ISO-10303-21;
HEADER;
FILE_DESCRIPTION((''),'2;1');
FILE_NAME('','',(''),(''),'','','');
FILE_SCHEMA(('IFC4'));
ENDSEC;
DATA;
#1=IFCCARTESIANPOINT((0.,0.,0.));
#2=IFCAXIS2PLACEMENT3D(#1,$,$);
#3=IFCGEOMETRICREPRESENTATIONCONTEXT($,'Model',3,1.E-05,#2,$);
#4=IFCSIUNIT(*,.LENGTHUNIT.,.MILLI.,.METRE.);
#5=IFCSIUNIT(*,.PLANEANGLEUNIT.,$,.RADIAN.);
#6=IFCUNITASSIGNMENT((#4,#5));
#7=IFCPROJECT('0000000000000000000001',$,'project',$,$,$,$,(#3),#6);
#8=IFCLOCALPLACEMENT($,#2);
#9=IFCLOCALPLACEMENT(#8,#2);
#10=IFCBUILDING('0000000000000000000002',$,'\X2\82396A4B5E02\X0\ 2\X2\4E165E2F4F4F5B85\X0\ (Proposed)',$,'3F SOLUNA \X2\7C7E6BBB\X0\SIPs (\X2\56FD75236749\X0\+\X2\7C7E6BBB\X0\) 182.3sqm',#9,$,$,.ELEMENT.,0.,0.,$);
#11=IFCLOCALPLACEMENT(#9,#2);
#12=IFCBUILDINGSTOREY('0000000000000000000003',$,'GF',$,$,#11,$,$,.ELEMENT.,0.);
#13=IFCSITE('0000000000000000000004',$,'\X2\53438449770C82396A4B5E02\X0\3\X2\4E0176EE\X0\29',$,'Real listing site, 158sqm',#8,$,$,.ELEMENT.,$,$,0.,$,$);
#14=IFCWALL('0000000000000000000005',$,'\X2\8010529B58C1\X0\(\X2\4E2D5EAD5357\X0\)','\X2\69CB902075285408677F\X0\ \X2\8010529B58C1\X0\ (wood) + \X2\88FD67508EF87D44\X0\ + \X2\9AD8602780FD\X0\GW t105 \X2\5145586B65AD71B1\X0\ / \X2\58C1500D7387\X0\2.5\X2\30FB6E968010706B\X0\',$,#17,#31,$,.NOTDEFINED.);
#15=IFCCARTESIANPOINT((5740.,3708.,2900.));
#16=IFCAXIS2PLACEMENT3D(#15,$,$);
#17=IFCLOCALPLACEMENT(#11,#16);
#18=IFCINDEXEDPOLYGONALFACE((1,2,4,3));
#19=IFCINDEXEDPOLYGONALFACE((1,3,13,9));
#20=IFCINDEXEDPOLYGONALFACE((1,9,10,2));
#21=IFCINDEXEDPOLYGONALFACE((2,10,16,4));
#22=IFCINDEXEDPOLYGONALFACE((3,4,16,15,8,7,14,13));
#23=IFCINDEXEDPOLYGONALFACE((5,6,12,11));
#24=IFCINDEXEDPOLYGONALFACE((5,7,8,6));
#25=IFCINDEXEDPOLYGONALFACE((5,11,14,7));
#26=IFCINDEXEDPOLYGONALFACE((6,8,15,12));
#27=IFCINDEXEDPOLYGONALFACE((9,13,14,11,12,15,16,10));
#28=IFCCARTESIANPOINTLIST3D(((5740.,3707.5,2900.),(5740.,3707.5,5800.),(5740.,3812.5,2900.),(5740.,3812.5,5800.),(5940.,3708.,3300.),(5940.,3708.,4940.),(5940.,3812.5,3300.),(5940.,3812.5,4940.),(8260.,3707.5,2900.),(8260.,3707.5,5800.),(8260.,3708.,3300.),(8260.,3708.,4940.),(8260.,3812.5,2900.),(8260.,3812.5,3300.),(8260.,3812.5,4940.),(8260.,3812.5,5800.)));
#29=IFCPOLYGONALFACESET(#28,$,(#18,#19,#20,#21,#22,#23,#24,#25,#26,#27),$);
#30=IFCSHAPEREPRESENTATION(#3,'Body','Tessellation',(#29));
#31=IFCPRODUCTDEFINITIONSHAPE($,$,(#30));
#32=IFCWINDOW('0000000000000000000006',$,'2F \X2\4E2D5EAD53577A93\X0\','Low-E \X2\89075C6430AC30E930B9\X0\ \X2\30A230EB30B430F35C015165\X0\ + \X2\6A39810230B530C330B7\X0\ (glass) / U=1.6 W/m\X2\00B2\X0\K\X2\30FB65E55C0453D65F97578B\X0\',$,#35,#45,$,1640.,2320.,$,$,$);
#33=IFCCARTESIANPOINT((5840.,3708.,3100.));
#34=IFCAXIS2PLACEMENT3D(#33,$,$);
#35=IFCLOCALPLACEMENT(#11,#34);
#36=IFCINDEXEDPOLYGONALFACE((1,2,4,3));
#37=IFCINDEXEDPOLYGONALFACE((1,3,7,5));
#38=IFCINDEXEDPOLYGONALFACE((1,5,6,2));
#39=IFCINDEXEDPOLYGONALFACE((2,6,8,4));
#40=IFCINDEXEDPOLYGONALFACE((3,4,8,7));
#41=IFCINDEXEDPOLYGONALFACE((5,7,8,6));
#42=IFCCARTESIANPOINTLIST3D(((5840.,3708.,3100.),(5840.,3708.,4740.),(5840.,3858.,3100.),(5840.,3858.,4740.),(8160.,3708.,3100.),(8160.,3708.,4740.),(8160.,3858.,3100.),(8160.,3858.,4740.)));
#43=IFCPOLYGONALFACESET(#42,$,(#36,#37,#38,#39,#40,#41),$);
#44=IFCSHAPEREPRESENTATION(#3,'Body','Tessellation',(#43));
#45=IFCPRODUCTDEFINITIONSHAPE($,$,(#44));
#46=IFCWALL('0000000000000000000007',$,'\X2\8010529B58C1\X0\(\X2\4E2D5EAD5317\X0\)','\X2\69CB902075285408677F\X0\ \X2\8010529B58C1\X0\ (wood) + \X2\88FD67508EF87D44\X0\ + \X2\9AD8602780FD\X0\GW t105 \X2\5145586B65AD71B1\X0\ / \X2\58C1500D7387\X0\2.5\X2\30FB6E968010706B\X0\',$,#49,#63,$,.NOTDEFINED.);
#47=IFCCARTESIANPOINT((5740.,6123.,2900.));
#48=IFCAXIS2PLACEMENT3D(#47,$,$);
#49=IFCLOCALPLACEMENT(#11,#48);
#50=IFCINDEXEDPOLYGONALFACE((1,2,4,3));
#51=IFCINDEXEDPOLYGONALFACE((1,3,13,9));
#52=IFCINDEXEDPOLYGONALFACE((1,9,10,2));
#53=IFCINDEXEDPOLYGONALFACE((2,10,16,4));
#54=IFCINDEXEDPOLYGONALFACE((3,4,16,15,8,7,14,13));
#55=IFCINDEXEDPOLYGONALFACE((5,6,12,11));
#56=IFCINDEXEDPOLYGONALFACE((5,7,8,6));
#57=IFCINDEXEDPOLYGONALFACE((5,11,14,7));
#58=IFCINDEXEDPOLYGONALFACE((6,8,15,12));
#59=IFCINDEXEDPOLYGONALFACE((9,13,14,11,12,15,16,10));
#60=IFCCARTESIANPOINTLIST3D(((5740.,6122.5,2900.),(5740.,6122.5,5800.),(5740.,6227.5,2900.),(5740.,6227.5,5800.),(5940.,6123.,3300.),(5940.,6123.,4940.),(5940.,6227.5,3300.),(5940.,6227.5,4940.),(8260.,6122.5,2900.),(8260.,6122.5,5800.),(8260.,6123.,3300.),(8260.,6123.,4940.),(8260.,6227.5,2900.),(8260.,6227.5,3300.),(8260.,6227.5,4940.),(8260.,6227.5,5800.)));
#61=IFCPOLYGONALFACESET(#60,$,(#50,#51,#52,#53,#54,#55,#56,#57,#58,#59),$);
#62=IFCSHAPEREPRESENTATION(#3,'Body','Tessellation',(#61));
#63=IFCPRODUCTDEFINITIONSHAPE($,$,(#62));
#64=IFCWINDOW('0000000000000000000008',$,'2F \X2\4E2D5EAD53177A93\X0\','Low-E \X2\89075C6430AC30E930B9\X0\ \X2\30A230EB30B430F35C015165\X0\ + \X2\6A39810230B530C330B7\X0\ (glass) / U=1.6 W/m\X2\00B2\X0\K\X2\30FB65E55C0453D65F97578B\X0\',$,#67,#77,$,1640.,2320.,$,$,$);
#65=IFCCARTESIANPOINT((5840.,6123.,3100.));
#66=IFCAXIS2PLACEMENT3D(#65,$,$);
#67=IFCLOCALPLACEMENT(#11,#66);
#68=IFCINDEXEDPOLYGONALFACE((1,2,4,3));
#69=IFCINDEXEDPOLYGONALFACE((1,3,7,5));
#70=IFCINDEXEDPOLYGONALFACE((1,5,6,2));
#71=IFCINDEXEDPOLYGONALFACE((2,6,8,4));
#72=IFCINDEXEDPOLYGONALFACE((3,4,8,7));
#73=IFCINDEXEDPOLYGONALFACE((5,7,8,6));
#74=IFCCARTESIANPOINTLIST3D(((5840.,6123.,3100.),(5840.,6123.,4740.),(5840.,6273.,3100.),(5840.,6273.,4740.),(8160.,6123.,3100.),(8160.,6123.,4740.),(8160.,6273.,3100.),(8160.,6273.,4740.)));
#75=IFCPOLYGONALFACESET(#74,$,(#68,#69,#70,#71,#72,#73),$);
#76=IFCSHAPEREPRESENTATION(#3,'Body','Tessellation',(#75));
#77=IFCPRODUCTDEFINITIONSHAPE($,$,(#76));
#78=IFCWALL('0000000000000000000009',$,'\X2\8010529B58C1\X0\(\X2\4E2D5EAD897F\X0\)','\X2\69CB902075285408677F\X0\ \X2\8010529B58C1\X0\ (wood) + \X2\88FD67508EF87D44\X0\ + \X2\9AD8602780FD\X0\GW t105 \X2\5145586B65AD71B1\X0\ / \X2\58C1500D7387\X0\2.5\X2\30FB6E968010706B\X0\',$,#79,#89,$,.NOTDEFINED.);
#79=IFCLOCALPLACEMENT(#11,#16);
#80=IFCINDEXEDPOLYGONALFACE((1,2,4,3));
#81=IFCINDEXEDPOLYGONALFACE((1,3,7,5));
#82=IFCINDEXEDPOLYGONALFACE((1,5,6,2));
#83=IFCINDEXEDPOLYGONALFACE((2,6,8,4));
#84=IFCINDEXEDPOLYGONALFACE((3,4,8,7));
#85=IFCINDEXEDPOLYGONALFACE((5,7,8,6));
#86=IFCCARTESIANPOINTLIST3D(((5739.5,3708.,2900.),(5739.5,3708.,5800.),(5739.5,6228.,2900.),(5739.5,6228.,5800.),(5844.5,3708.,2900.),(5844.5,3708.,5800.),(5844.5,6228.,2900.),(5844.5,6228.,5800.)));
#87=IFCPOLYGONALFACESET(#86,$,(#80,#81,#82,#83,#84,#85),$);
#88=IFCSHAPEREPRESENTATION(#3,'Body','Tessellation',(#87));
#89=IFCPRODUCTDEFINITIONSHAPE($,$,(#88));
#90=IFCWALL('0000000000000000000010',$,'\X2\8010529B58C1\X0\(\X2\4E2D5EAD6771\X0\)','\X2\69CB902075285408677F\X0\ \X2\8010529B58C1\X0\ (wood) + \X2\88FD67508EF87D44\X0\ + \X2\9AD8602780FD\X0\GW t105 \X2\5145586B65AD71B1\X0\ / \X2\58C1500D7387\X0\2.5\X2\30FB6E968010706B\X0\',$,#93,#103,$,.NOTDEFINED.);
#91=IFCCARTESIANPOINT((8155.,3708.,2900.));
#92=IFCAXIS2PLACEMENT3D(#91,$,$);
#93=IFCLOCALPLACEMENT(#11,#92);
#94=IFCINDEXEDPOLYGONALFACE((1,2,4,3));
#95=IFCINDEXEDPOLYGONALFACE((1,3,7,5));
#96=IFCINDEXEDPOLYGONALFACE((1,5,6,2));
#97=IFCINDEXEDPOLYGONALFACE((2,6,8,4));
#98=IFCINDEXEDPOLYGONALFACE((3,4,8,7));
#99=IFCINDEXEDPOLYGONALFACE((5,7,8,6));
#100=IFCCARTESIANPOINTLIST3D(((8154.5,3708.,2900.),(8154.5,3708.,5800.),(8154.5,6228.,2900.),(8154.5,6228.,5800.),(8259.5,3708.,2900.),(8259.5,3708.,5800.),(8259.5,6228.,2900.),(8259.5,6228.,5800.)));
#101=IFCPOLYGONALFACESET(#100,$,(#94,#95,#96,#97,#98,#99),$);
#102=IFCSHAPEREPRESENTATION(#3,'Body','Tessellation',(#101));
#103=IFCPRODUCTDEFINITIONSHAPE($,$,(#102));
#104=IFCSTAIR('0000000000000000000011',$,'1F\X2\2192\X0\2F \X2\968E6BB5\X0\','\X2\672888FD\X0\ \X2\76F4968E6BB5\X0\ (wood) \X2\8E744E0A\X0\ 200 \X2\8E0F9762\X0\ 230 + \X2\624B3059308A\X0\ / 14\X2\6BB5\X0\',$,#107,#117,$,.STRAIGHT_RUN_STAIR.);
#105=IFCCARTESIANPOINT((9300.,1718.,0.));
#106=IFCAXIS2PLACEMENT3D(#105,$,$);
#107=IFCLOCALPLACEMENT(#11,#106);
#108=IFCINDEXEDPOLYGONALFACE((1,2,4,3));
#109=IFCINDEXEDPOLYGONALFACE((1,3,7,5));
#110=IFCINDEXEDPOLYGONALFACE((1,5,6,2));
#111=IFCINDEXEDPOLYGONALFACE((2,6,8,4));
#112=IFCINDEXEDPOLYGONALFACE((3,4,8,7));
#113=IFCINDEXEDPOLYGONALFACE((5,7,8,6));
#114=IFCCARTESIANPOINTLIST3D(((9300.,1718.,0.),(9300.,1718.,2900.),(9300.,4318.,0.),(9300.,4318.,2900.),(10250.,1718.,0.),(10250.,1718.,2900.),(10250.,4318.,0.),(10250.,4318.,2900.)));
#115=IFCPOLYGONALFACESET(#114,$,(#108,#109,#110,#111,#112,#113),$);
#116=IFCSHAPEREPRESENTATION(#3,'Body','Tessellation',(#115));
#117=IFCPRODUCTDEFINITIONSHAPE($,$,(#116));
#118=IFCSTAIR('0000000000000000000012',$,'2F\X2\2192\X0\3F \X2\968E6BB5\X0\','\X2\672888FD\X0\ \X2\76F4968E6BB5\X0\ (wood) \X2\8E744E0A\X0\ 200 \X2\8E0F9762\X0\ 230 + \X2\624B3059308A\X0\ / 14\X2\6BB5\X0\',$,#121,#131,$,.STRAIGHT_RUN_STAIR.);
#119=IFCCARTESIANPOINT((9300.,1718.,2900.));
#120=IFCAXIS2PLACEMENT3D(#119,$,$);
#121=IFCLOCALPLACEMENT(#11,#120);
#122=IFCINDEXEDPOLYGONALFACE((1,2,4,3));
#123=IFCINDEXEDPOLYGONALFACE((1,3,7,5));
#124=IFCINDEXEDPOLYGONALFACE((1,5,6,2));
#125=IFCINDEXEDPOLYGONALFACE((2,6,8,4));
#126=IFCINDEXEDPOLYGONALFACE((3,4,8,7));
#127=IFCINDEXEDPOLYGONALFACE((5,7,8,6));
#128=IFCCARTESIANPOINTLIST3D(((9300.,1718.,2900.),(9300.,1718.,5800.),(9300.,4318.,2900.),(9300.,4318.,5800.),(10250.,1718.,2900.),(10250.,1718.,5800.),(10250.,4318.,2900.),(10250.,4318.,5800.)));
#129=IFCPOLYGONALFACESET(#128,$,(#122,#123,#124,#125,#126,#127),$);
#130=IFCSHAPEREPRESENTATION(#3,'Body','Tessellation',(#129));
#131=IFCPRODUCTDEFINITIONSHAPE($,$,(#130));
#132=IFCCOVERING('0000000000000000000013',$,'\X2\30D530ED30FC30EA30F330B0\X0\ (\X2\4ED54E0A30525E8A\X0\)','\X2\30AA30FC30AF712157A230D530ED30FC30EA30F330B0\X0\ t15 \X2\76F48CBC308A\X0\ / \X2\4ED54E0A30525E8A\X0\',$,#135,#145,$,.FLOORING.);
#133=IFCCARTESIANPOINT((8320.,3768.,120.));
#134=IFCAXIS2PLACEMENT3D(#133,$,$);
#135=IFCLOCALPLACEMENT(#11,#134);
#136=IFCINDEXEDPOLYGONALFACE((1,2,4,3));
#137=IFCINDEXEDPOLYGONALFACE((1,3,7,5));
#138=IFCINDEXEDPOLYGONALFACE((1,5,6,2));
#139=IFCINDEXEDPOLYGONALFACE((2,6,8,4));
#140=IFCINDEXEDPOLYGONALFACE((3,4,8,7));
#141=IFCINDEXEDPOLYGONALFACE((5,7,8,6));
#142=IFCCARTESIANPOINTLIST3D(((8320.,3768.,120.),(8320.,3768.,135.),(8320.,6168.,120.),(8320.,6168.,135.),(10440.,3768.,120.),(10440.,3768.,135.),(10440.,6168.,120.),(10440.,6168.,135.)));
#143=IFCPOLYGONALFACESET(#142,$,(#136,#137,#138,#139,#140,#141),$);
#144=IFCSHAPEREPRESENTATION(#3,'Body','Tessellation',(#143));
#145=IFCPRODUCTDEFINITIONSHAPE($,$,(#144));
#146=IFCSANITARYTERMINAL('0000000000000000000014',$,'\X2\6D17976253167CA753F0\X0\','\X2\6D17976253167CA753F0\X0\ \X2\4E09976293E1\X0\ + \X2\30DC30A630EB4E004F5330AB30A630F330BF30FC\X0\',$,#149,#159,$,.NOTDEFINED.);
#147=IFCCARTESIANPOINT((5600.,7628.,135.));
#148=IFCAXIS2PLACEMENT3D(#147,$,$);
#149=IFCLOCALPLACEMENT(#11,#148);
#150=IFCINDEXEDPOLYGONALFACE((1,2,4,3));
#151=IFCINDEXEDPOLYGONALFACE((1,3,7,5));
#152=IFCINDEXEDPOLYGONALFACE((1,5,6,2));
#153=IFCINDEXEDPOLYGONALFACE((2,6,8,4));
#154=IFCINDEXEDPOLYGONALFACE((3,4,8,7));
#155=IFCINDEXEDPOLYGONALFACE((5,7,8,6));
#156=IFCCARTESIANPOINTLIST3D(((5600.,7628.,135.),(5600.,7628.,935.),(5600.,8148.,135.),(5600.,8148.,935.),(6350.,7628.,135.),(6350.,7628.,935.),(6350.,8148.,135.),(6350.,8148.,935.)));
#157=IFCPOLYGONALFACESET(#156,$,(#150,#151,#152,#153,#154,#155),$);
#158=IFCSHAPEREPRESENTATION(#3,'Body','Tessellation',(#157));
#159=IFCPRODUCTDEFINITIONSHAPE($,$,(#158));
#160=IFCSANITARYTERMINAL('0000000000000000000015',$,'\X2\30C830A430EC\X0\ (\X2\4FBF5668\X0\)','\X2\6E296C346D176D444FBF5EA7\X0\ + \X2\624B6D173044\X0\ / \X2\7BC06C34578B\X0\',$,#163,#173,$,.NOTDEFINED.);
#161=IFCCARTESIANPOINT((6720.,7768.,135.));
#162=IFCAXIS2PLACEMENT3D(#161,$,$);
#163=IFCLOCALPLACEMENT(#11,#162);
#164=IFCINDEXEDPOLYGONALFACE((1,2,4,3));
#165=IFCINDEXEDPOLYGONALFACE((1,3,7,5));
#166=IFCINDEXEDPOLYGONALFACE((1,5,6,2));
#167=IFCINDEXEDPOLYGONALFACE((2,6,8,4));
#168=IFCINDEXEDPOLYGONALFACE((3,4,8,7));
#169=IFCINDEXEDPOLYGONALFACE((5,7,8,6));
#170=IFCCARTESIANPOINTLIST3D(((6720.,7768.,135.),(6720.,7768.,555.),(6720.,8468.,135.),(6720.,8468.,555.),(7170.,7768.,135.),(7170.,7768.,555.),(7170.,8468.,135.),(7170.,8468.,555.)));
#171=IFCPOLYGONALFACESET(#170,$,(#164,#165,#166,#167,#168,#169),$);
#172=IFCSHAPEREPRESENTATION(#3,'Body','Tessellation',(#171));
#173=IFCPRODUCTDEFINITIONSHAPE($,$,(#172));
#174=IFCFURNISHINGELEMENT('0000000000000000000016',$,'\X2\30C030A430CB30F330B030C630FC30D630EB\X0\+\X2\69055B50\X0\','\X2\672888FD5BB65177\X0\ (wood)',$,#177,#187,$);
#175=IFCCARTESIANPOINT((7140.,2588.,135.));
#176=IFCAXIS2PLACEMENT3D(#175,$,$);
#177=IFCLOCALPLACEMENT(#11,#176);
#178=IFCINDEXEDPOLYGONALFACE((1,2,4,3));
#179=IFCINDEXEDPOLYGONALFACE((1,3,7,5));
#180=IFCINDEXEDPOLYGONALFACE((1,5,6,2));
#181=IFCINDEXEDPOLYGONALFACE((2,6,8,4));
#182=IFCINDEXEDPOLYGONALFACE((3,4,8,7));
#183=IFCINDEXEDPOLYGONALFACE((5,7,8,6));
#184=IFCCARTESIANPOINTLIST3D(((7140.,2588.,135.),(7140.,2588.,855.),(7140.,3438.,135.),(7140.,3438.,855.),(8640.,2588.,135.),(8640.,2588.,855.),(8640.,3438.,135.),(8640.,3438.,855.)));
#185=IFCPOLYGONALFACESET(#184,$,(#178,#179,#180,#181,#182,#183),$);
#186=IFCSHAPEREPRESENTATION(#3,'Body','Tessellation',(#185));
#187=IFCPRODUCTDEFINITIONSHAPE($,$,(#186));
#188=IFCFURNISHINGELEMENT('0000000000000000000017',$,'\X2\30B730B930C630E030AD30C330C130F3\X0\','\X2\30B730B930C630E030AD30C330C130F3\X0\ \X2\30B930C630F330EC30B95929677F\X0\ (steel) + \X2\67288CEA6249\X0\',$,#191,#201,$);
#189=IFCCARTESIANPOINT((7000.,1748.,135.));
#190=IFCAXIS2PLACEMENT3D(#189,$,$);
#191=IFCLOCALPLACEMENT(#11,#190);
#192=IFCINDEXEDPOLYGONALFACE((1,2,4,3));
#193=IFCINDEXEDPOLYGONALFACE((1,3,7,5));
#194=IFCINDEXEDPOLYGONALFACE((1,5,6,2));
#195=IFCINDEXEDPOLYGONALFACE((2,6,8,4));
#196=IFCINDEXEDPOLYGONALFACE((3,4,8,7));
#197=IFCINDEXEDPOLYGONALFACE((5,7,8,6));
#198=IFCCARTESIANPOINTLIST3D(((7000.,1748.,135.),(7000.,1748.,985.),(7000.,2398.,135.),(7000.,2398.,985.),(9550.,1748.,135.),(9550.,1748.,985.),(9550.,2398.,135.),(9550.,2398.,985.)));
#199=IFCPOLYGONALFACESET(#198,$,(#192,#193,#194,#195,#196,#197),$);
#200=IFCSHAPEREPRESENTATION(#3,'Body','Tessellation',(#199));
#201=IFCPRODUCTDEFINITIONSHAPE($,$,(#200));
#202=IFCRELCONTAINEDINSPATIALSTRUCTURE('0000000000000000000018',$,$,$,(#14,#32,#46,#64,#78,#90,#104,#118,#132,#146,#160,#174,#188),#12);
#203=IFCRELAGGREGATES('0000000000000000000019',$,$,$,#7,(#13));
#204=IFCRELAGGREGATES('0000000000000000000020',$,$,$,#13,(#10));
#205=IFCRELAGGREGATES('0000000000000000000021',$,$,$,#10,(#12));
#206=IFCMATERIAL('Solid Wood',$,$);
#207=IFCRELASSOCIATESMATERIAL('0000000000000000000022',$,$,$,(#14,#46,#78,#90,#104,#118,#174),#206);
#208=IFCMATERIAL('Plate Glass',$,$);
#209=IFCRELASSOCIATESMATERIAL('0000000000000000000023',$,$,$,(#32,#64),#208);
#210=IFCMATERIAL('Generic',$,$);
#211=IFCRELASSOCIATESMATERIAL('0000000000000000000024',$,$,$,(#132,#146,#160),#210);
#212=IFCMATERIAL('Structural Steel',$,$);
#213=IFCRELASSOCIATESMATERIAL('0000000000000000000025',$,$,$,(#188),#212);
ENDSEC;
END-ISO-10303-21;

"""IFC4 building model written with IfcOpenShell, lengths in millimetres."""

from ifc_helpers import new_model, si_unit, frame, frame_2d, origin, place, context, project, spatial, rectangle, extrude, material, element, fill, save


model = new_model("IFC4")

# Units and contexts
model_context = context("Model", 3, precision=1e-05, world=origin())
ifc_project = project(units=[si_unit("LENGTHUNIT", "METRE", prefix="MILLI"), si_unit("PLANEANGLEUNIT", "RADIAN")], contexts=[model_context])

# Site, building, storey
site_placement = place(None, origin())
site = spatial("IfcSite", under=ifc_project, at=site_placement, Name="千葉県船橋市3丁目29", ObjectType="Real listing site, 158sqm", CompositionType="ELEMENT", RefElevation=0.0)
building_placement = place(site_placement, origin())
building = spatial("IfcBuilding", under=site, at=building_placement, Name="船橋市 2世帯住宅 (Proposed)", ObjectType="3F SOLUNA 籾殻SIPs (国産杉+籾殻) 182.3sqm", CompositionType="ELEMENT", ElevationOfRefHeight=0.0, ElevationOfTerrain=0.0)
storey_placement = place(building_placement, origin())
storey = spatial("IfcBuildingStorey", under=building, at=storey_placement, Name="GF", CompositionType="ELEMENT", Elevation=0.0)

# Shared definitions
ifc_material_1 = material(Name="Solid Wood")

# Shared definitions
ifc_material_2 = material(Name="Plate Glass")

# Walls, openings, windows
wall_1_placement = place(storey_placement, frame((5740.0, 3708.0, 2900.0)))
wall_1 = element("IfcWall", 1, at=wall_1_placement, inside=storey, material=ifc_material_1, Name="耐力壁(中庭南)", Description="構造用合板 耐力壁 (wood) + 製材軸組 + 高性能GW t105 充填断熱 / 壁倍率2.5・準耐火", PredefinedType="NOTDEFINED", context=model_context, shape_type="SweptSolid", body=[
    extrude(rectangle(XDim=2520.0, YDim=105.0, at=frame_2d((1260.0, 52.0))), frame((5740.0, 3708.0, 2900.0)), (0.0, 0.0, 1.0), 2900.0),
])
opening_1_placement = place(storey_placement, frame((5840.0, 3708.0, 3100.0)))
opening_1 = element("IfcOpeningElement", 2, at=opening_1_placement, cuts=wall_1, PredefinedType="NOTDEFINED", context=model_context, shape_type="SweptSolid", body=[
    extrude(rectangle(XDim=2320.0, YDim=150.0, at=frame_2d((1160.0, 75.0))), frame((5840.0, 3708.0, 3100.0)), (0.0, 0.0, 1.0), 1640.0),
])
window_1_placement = place(storey_placement, frame((5840.0, 3708.0, 3100.0)))
window_1 = element("IfcWindow", 3, at=window_1_placement, inside=storey, material=ifc_material_2, Name="2F 中庭南窓", Description="Low-E 複層ガラス アルゴン封入 + 樹脂サッシ (glass) / U=1.6 W/m²K・日射取得型", OverallHeight=1640.0, OverallWidth=2320.0, context=model_context, shape_type="SweptSolid", body=[
    extrude(rectangle(XDim=2320.0, YDim=150.0, at=frame_2d((1160.0, 75.0))), frame((5840.0, 3708.0, 3100.0)), (0.0, 0.0, 1.0), 1640.0),
])
fill(opening_1, window_1)
wall_2_placement = place(storey_placement, frame((5740.0, 6123.0, 2900.0)))
wall_2 = element("IfcWall", 4, at=wall_2_placement, inside=storey, material=ifc_material_1, Name="耐力壁(中庭北)", Description="構造用合板 耐力壁 (wood) + 製材軸組 + 高性能GW t105 充填断熱 / 壁倍率2.5・準耐火", PredefinedType="NOTDEFINED", context=model_context, shape_type="SweptSolid", body=[
    extrude(rectangle(XDim=2520.0, YDim=105.0, at=frame_2d((1260.0, 52.0))), frame((5740.0, 6123.0, 2900.0)), (0.0, 0.0, 1.0), 2900.0),
])
opening_2_placement = place(storey_placement, frame((5840.0, 6123.0, 3100.0)))
opening_2 = element("IfcOpeningElement", 5, at=opening_2_placement, cuts=wall_2, PredefinedType="NOTDEFINED", context=model_context, shape_type="SweptSolid", body=[
    extrude(rectangle(XDim=2320.0, YDim=150.0, at=frame_2d((1160.0, 75.0))), frame((5840.0, 6123.0, 3100.0)), (0.0, 0.0, 1.0), 1640.0),
])
window_2_placement = place(storey_placement, frame((5840.0, 6123.0, 3100.0)))
window_2 = element("IfcWindow", 6, at=window_2_placement, inside=storey, material=ifc_material_2, Name="2F 中庭北窓", Description="Low-E 複層ガラス アルゴン封入 + 樹脂サッシ (glass) / U=1.6 W/m²K・日射取得型", OverallHeight=1640.0, OverallWidth=2320.0, context=model_context, shape_type="SweptSolid", body=[
    extrude(rectangle(XDim=2320.0, YDim=150.0, at=frame_2d((1160.0, 75.0))), frame((5840.0, 6123.0, 3100.0)), (0.0, 0.0, 1.0), 1640.0),
])
fill(opening_2, window_2)

# Walls
wall_3_placement = place(storey_placement, frame((5740.0, 3708.0, 2900.0)))
element("IfcWall", 7, at=wall_3_placement, inside=storey, material=ifc_material_1, Name="耐力壁(中庭西)", Description="構造用合板 耐力壁 (wood) + 製材軸組 + 高性能GW t105 充填断熱 / 壁倍率2.5・準耐火", PredefinedType="NOTDEFINED", context=model_context, shape_type="SweptSolid", body=[
    extrude(rectangle(XDim=105.0, YDim=2520.0, at=frame_2d((52.0, 1260.0))), frame((5740.0, 3708.0, 2900.0)), (0.0, 0.0, 1.0), 2900.0),
])
wall_4_placement = place(storey_placement, frame((8155.0, 3708.0, 2900.0)))
element("IfcWall", 8, at=wall_4_placement, inside=storey, material=ifc_material_1, Name="耐力壁(中庭東)", Description="構造用合板 耐力壁 (wood) + 製材軸組 + 高性能GW t105 充填断熱 / 壁倍率2.5・準耐火", PredefinedType="NOTDEFINED", context=model_context, shape_type="SweptSolid", body=[
    extrude(rectangle(XDim=105.0, YDim=2520.0, at=frame_2d((52.0, 1260.0))), frame((8155.0, 3708.0, 2900.0)), (0.0, 0.0, 1.0), 2900.0),
])

# Stairs
stair_1_placement = place(storey_placement, frame((9300.0, 1718.0, 0.0)))
element("IfcStair", 9, at=stair_1_placement, inside=storey, material=ifc_material_1, Name="1F→2F 階段", Description="木製 直階段 (wood) 蹴上 200 踏面 230 + 手すり / 14段", PredefinedType="STRAIGHT_RUN_STAIR", context=model_context, shape_type="SweptSolid", body=[
    extrude(rectangle(XDim=950.0, YDim=2600.0, at=frame_2d((475.0, 1300.0))), frame((9300.0, 1718.0, 0.0)), (0.0, 0.0, 1.0), 2900.0),
])
stair_2_placement = place(storey_placement, frame((9300.0, 1718.0, 2900.0)))
element("IfcStair", 10, at=stair_2_placement, inside=storey, material=ifc_material_1, Name="2F→3F 階段", Description="木製 直階段 (wood) 蹴上 200 踏面 230 + 手すり / 14段", PredefinedType="STRAIGHT_RUN_STAIR", context=model_context, shape_type="SweptSolid", body=[
    extrude(rectangle(XDim=950.0, YDim=2600.0, at=frame_2d((475.0, 1300.0))), frame((9300.0, 1718.0, 2900.0)), (0.0, 0.0, 1.0), 2900.0),
])

# Covering
ifc_material_3 = material(Name="Generic")
covering_placement = place(storey_placement, frame((8320.0, 3768.0, 120.0)))
element("IfcCovering", 11, at=covering_placement, inside=storey, material=ifc_material_3, Name="フローリング (仕上げ床)", Description="オーク無垢フローリング t15 直貼り / 仕上げ床", PredefinedType="FLOORING", context=model_context, shape_type="SweptSolid", body=[
    extrude(rectangle(XDim=2120.0, YDim=2400.0, at=frame_2d((1060.0, 1200.0))), frame((8320.0, 3768.0, 120.0)), (0.0, 0.0, 1.0), 15.0),
])

# Sanitary terminals
sanitary_terminal_1_placement = place(storey_placement, frame((5600.0, 7628.0, 135.0)))
element("IfcSanitaryTerminal", 12, at=sanitary_terminal_1_placement, inside=storey, material=ifc_material_3, Name="洗面化粧台", Description="洗面化粧台 三面鏡 + ボウル一体カウンター", PredefinedType="NOTDEFINED", context=model_context, shape_type="SweptSolid", body=[
    extrude(rectangle(XDim=750.0, YDim=520.0, at=frame_2d((375.0, 260.0))), frame((5600.0, 7628.0, 135.0)), (0.0, 0.0, 1.0), 800.0),
])
sanitary_terminal_2_placement = place(storey_placement, frame((6720.0, 7768.0, 135.0)))
element("IfcSanitaryTerminal", 13, at=sanitary_terminal_2_placement, inside=storey, material=ifc_material_3, Name="トイレ (便器)", Description="温水洗浄便座 + 手洗い / 節水型", PredefinedType="NOTDEFINED", context=model_context, shape_type="SweptSolid", body=[
    extrude(rectangle(XDim=450.0, YDim=700.0, at=frame_2d((225.0, 350.0))), frame((6720.0, 7768.0, 135.0)), (0.0, 0.0, 1.0), 420.0),
])

# Furnishing elements
furnishing_1_placement = place(storey_placement, frame((7140.0, 2588.0, 135.0)))
element("IfcFurnishingElement", 14, at=furnishing_1_placement, inside=storey, material=ifc_material_1, Name="ダイニングテーブル+椅子", Description="木製家具 (wood)", context=model_context, shape_type="SweptSolid", body=[
    extrude(rectangle(XDim=1500.0, YDim=850.0, at=frame_2d((750.0, 425.0))), frame((7140.0, 2588.0, 135.0)), (0.0, 0.0, 1.0), 720.0),
])
ifc_material_4 = material(Name="Structural Steel")
furnishing_2_placement = place(storey_placement, frame((7000.0, 1748.0, 135.0)))
element("IfcFurnishingElement", 15, at=furnishing_2_placement, inside=storey, material=ifc_material_4, Name="システムキッチン", Description="システムキッチン ステンレス天板 (steel) + 木質扉", context=model_context, shape_type="SweptSolid", body=[
    extrude(rectangle(XDim=2550.0, YDim=650.0, at=frame_2d((1275.0, 325.0))), frame((7000.0, 1748.0, 135.0)), (0.0, 0.0, 1.0), 850.0),
])

save(model, "model.ifc")
